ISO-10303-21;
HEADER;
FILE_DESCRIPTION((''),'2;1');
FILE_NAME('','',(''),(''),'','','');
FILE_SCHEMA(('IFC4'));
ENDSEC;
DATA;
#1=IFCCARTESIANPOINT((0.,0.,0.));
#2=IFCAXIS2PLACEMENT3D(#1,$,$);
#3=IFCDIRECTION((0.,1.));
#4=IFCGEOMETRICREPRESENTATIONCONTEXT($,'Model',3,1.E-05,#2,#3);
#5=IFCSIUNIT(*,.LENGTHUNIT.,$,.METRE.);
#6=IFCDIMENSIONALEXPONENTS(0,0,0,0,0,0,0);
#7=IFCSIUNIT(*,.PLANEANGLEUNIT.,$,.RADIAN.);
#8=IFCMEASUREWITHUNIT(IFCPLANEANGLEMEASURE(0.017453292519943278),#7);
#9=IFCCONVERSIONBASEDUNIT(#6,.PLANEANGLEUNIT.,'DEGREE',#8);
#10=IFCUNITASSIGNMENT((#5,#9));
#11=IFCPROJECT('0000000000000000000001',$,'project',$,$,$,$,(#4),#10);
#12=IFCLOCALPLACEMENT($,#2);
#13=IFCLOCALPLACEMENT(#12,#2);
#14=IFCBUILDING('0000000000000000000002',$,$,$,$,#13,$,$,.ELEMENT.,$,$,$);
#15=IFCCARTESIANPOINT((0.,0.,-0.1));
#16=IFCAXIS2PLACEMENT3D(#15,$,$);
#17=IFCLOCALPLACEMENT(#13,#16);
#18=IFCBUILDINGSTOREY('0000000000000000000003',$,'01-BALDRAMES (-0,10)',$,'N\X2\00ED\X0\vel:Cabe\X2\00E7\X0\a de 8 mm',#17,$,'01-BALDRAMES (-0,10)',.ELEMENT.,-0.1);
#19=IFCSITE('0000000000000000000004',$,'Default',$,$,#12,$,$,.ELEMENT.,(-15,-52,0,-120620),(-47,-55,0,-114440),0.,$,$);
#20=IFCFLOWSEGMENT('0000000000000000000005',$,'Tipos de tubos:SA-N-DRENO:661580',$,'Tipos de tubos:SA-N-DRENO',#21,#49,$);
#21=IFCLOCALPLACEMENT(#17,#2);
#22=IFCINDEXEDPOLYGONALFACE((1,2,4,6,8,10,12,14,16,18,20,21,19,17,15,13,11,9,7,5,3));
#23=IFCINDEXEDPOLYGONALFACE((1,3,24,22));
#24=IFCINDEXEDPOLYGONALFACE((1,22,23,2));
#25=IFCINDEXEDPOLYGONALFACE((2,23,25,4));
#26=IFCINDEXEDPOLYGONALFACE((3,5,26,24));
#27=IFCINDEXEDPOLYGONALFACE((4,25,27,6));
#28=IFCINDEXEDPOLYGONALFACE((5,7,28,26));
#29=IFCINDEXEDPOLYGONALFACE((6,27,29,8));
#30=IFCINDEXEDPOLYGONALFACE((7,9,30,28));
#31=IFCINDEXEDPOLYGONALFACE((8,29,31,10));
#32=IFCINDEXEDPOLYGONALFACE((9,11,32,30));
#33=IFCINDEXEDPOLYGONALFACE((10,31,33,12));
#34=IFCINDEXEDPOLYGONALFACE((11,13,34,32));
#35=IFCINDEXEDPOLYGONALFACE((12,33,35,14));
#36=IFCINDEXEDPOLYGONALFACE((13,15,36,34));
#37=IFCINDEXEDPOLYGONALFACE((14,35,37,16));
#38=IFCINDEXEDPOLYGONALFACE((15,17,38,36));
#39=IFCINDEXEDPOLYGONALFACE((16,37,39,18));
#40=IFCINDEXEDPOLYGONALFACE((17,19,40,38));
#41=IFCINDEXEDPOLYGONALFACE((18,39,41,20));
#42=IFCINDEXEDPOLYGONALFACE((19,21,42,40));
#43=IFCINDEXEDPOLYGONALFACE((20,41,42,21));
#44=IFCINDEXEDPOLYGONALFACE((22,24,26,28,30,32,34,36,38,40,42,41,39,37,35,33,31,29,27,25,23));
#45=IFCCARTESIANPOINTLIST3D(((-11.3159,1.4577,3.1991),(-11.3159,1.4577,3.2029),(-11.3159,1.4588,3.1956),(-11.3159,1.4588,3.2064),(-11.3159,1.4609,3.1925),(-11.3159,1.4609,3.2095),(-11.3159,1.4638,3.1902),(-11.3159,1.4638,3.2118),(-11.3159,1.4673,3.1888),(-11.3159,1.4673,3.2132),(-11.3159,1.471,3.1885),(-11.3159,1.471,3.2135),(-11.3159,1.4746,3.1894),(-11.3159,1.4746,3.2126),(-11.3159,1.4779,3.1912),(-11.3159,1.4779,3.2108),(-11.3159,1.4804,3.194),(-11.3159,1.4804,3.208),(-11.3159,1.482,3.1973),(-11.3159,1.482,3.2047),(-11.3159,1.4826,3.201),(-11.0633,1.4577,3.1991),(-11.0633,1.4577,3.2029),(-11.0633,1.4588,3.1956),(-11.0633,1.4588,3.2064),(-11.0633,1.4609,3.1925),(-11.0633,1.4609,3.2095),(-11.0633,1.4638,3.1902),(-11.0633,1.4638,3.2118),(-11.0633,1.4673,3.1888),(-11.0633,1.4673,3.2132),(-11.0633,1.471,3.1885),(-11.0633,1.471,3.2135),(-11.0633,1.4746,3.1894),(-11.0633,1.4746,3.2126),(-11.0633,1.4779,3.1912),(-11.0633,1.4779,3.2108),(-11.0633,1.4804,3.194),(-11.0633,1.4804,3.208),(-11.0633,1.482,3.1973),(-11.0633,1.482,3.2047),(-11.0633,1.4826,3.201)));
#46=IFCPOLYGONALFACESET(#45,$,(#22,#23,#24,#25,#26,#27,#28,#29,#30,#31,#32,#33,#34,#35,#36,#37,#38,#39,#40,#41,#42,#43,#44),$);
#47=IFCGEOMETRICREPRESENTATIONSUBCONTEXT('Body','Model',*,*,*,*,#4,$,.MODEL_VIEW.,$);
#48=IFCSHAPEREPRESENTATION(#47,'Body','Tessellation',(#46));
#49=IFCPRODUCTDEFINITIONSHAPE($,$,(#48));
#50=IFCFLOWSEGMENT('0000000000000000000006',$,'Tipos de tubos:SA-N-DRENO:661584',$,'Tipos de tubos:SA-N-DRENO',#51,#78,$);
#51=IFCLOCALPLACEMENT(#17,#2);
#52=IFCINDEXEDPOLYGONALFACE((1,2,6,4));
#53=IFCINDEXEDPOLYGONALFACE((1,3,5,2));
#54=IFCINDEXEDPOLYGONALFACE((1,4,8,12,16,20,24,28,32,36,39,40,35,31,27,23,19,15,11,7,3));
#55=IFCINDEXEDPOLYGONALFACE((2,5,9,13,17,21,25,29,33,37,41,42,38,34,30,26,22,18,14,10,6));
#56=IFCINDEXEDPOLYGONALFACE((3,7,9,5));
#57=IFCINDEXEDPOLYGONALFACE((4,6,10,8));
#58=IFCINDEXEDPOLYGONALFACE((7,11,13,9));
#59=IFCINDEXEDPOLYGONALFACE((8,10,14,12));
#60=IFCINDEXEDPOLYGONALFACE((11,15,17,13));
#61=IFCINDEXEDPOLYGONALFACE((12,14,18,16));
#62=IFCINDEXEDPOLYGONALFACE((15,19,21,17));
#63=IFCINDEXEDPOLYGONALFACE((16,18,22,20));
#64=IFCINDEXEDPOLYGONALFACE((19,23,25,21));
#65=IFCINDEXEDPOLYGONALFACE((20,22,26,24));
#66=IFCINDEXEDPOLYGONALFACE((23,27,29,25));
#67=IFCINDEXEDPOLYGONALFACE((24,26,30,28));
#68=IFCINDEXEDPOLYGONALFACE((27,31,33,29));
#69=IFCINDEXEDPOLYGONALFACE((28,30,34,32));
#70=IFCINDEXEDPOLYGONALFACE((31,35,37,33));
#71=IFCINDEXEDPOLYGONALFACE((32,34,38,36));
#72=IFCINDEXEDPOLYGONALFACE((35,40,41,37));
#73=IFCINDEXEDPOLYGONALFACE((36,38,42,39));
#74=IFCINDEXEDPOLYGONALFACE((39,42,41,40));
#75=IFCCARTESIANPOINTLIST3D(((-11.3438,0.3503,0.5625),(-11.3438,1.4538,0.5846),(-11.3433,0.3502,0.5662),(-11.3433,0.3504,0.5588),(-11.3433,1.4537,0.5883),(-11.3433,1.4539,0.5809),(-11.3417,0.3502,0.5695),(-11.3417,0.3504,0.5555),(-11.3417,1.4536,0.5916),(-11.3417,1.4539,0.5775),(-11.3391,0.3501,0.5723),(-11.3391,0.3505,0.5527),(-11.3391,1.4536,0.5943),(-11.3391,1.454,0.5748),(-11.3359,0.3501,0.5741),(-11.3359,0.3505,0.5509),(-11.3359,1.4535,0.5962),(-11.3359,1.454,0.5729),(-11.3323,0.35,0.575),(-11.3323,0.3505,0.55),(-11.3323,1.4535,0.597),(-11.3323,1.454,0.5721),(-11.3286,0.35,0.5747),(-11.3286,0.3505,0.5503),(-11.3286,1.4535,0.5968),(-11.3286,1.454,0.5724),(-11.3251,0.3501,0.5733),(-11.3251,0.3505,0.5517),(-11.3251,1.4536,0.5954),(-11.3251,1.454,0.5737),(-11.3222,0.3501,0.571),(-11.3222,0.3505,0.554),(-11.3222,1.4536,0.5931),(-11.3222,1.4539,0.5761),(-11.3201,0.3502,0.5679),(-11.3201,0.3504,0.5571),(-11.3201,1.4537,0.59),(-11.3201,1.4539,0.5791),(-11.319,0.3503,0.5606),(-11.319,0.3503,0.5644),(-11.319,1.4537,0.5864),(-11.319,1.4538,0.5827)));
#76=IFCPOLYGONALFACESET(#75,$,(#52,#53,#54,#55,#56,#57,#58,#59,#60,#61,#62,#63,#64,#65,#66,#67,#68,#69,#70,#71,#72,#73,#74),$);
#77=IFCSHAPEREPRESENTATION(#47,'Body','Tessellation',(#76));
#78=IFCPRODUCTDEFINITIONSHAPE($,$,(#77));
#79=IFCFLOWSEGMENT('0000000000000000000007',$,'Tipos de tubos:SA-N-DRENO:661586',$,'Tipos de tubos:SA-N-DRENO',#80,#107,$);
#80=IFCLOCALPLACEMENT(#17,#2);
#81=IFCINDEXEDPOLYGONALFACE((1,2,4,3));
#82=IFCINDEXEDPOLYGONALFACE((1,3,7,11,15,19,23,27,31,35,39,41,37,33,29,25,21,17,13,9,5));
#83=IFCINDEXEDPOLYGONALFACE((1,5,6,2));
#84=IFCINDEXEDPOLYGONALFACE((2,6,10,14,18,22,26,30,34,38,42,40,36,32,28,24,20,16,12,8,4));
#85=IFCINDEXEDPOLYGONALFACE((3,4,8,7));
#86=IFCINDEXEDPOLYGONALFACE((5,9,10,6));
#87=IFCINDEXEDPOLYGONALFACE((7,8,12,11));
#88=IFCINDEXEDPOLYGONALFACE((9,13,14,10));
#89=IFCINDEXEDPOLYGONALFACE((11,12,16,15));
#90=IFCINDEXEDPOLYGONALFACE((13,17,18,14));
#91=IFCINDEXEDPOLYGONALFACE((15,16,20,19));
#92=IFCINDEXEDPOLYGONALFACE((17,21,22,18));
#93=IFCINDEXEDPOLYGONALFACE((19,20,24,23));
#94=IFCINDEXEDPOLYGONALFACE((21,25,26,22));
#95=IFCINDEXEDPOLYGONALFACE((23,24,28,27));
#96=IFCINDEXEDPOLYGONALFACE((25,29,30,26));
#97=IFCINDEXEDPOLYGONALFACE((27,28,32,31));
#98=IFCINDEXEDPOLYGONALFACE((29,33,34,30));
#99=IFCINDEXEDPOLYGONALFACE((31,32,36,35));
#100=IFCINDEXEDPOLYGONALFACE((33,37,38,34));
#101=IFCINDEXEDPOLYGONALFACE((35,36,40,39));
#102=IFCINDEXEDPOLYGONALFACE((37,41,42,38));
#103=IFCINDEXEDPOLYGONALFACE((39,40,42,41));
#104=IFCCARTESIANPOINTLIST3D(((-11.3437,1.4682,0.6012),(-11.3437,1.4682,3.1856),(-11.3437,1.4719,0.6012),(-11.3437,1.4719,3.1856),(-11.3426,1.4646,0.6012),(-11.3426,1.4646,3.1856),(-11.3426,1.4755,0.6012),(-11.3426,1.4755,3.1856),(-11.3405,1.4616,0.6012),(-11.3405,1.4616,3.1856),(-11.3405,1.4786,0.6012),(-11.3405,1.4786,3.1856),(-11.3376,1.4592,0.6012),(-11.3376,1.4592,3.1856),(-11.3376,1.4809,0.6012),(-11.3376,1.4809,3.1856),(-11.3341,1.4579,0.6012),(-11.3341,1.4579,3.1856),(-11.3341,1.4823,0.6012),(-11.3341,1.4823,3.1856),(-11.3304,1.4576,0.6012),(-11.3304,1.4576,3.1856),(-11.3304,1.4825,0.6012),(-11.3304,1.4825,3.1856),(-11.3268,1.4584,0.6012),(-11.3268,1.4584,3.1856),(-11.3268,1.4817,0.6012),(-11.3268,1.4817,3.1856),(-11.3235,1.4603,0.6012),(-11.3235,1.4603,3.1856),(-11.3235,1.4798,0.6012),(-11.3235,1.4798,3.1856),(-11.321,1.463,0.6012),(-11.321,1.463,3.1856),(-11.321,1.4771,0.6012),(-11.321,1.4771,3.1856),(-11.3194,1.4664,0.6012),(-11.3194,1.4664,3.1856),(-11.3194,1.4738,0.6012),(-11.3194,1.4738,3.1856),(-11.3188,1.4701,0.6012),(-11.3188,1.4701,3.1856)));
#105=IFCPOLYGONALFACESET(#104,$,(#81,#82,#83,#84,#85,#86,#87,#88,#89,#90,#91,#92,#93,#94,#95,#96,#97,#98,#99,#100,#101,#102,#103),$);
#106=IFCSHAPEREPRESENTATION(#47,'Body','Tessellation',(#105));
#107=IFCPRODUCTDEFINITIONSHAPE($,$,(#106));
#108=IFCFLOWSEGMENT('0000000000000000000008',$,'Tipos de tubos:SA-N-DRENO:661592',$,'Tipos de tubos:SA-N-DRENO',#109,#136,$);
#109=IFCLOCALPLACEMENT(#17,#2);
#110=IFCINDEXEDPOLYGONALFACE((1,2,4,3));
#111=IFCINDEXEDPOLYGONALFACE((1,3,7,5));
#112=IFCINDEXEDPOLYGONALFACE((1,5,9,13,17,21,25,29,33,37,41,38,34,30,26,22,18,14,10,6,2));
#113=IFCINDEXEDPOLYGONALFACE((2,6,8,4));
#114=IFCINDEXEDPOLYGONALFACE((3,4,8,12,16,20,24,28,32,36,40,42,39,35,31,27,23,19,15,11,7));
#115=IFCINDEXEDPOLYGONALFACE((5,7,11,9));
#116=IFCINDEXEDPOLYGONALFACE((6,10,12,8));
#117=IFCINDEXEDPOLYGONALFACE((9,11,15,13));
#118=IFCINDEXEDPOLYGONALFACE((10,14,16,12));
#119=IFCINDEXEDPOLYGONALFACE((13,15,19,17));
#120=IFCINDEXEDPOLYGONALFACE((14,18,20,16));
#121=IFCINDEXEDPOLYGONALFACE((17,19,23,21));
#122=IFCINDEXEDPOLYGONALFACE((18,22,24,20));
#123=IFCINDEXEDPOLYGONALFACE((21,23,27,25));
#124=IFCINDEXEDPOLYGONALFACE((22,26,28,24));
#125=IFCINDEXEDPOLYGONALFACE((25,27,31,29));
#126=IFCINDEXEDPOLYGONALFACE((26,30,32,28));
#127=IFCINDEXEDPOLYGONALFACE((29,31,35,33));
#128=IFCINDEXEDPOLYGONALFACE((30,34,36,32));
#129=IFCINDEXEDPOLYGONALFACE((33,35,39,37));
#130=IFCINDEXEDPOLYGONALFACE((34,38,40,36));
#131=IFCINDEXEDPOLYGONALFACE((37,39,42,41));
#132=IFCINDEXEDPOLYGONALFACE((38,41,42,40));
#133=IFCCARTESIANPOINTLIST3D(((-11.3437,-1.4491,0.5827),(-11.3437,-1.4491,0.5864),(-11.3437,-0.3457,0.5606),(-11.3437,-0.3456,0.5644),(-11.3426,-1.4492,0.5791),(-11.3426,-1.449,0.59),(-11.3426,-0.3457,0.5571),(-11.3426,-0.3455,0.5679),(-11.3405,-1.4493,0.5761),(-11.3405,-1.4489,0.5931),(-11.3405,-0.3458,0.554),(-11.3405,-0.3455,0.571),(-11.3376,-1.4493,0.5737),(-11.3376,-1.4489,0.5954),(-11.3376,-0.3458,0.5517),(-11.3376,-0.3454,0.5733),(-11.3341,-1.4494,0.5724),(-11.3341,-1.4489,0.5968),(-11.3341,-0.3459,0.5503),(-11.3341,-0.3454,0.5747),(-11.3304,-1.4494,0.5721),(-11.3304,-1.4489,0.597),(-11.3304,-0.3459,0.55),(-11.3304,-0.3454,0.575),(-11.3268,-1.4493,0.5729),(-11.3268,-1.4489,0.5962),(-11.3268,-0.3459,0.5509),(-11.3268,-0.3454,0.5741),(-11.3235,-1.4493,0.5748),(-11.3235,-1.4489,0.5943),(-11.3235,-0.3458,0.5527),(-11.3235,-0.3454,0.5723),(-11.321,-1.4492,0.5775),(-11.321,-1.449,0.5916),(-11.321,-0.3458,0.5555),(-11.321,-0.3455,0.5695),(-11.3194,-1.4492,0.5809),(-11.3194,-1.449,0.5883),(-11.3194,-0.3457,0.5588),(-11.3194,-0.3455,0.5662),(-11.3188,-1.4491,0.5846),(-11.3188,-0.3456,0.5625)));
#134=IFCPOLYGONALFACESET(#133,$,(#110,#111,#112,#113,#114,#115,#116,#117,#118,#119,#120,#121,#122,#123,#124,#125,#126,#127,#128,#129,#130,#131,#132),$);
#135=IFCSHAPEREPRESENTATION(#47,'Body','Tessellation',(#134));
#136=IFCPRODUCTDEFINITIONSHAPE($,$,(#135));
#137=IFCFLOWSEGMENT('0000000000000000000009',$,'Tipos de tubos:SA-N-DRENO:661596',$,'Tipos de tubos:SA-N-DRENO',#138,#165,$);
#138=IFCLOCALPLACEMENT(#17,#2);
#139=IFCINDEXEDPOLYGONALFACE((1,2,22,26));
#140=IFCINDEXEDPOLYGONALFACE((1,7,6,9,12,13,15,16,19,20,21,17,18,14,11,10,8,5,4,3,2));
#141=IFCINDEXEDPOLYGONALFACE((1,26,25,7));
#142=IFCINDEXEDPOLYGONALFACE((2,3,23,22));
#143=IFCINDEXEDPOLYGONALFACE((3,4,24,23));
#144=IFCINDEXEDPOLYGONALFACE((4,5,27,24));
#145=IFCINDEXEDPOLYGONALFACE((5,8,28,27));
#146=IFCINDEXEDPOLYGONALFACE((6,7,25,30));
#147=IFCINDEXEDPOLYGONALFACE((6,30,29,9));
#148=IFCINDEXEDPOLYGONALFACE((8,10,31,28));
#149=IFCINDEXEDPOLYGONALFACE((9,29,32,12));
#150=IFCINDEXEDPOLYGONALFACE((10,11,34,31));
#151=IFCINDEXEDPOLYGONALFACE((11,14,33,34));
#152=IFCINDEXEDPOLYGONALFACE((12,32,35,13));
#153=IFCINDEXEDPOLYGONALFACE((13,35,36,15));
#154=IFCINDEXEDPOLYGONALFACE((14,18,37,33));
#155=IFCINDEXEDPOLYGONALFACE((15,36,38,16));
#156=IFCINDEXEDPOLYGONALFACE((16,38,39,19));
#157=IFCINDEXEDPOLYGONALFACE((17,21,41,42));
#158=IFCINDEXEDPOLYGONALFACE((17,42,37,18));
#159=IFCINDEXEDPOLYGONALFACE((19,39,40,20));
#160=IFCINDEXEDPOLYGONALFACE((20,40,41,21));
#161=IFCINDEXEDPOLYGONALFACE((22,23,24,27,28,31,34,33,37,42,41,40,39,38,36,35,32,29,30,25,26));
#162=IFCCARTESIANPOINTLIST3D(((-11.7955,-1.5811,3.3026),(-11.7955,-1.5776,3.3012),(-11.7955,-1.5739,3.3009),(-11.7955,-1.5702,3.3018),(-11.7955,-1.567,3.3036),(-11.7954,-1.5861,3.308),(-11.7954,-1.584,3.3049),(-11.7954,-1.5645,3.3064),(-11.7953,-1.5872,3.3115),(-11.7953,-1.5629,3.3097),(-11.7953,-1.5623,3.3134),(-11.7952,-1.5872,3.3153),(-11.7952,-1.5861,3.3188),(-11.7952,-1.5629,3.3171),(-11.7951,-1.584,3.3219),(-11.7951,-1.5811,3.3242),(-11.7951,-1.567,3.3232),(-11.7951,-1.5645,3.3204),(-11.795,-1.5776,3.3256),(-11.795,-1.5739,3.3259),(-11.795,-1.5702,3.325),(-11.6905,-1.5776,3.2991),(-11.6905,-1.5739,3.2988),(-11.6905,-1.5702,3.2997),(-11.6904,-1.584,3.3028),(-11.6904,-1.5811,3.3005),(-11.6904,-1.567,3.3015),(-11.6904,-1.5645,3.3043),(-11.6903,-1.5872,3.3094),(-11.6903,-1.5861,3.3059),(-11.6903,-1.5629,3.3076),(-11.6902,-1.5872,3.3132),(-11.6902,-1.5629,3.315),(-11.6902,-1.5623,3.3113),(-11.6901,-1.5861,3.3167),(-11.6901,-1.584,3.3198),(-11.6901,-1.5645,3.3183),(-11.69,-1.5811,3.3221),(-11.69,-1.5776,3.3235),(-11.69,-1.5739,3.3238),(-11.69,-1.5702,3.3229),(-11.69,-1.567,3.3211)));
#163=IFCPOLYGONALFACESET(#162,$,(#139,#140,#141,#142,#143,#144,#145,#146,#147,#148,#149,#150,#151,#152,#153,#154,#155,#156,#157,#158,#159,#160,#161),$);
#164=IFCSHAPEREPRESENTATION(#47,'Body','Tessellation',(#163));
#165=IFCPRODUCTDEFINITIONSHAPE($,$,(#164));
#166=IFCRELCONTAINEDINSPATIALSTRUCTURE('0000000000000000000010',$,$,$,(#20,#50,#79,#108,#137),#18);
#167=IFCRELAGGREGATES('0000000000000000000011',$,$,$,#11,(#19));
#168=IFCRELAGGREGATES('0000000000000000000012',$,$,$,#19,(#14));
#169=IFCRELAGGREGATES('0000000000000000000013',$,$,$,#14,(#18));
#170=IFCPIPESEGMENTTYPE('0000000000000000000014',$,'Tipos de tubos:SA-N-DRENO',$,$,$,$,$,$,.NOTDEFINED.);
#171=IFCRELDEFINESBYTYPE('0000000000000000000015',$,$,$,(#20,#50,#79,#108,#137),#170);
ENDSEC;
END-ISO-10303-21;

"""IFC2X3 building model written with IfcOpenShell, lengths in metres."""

from ifc_helpers import new_model, entity, si_unit, converted_unit, direction, frame, frame_2d, origin, origin_2d_with_axis, place, context, subcontext, project, spatial, circle, extrude, type_object, element, save


model = new_model("IFC2X3")

# Units and contexts
model_context = context("Model", 3, precision=1e-05, world=origin(), true_north=direction((0.0, 1.0)))
body_context = subcontext(model_context, "Body", "Model", "MODEL_VIEW")
ifc_project = project(units=[si_unit("LENGTHUNIT", "METRE"), converted_unit("PLANEANGLEUNIT", "DEGREE", entity("IfcPlaneAngleMeasure", 0.017453292519943278), si_unit("PLANEANGLEUNIT", "RADIAN"), dimensions=[0, 0, 0, 0, 0, 0, 0])], contexts=[model_context])

# Site, building, storey
site_placement = place(None, origin())
site = spatial("IfcSite", under=ifc_project, at=site_placement, Name="Default", CompositionType="ELEMENT", RefLatitude=(-15, -52, 0, -120620), RefLongitude=(-47, -55, 0, -114440), RefElevation=0.0)
building_placement = place(site_placement, origin())
building = spatial("IfcBuilding", under=site, at=building_placement, CompositionType="ELEMENT")
storey_placement = place(building_placement, frame((0.0, 0.0, -0.1)))
storey = spatial("IfcBuildingStorey", under=building, at=storey_placement, Name="01-BALDRAMES (-0,10)", ObjectType="Nível:Cabeça de 8 mm", LongName="01-BALDRAMES (-0,10)", CompositionType="ELEMENT", Elevation=-0.1)

# Flow segments
pipe_segment_type_1 = type_object("IfcPipeSegmentType", Name="Tipos de tubos:SA-N-DRENO", PredefinedType="NOTDEFINED")
flow_segment_1_placement = place(storey_placement, origin())
element("IfcFlowSegment", 1, at=flow_segment_1_placement, inside=storey, type_object=pipe_segment_type_1, Name="Tipos de tubos:SA-N-DRENO:661580", ObjectType="Tipos de tubos:SA-N-DRENO", context=body_context, shape_type="SweptSolid", body=[
    extrude(circle(Radius=0.0125, at=origin_2d_with_axis()), frame((-11.3159, 1.4701, 3.201), z_axis=(1.0, 0.0, 0.0), x_axis=(0.0, 1.0, 0.0)), (0.0, 0.0, 1.0), 0.2526),
])
flow_segment_2_placement = place(storey_placement, origin())
element("IfcFlowSegment", 2, at=flow_segment_2_placement, inside=storey, type_object=pipe_segment_type_1, Name="Tipos de tubos:SA-N-DRENO:661584", ObjectType="Tipos de tubos:SA-N-DRENO", context=body_context, shape_type="SweptSolid", body=[
    extrude(circle(Radius=0.0125, at=frame_2d((0.0, 0.0), x_axis=(1.0, 0.0))), frame((-11.3313, 0.3503, 0.5625), z_axis=(-0.000001, 0.9998, 0.019996), x_axis=(-1.0, -0.000001, 0.0)), (0.0, 0.0, 1.0), 1.1037),
])
flow_segment_3_placement = place(storey_placement, origin())
element("IfcFlowSegment", 3, at=flow_segment_3_placement, inside=storey, type_object=pipe_segment_type_1, Name="Tipos de tubos:SA-N-DRENO:661586", ObjectType="Tipos de tubos:SA-N-DRENO", context=body_context, shape_type="SweptSolid", body=[
    extrude(circle(Radius=0.0125, at=origin_2d_with_axis()), frame((-11.3313, 1.4701, 0.6012)), (0.0, 0.0, 1.0), 2.5844),
])
flow_segment_4_placement = place(storey_placement, origin())
element("IfcFlowSegment", 4, at=flow_segment_4_placement, inside=storey, type_object=pipe_segment_type_1, Name="Tipos de tubos:SA-N-DRENO:661592", ObjectType="Tipos de tubos:SA-N-DRENO", context=body_context, shape_type="SweptSolid", body=[
    extrude(circle(Radius=0.0125, at=origin_2d_with_axis()), frame((-11.3313, -1.4491, 0.5846), z_axis=(-0.000001, 0.9998, -0.019996), x_axis=(1.0, 0.000001, 0.0)), (0.0, 0.0, 1.0), 1.1037),
])
flow_segment_5_placement = place(storey_placement, origin())
element("IfcFlowSegment", 5, at=flow_segment_5_placement, inside=storey, type_object=pipe_segment_type_1, Name="Tipos de tubos:SA-N-DRENO:661596", ObjectType="Tipos de tubos:SA-N-DRENO", context=body_context, shape_type="SweptSolid", body=[
    extrude(circle(Radius=0.0125, at=origin_2d_with_axis()), frame((-11.7953, -1.5748, 3.3134), z_axis=(0.9998, -0.000041, -0.019996), x_axis=(0.000041, 1.0, 0.0)), (0.0, 0.0, 1.0), 0.1051),
])

save(model, "model.ifc")
